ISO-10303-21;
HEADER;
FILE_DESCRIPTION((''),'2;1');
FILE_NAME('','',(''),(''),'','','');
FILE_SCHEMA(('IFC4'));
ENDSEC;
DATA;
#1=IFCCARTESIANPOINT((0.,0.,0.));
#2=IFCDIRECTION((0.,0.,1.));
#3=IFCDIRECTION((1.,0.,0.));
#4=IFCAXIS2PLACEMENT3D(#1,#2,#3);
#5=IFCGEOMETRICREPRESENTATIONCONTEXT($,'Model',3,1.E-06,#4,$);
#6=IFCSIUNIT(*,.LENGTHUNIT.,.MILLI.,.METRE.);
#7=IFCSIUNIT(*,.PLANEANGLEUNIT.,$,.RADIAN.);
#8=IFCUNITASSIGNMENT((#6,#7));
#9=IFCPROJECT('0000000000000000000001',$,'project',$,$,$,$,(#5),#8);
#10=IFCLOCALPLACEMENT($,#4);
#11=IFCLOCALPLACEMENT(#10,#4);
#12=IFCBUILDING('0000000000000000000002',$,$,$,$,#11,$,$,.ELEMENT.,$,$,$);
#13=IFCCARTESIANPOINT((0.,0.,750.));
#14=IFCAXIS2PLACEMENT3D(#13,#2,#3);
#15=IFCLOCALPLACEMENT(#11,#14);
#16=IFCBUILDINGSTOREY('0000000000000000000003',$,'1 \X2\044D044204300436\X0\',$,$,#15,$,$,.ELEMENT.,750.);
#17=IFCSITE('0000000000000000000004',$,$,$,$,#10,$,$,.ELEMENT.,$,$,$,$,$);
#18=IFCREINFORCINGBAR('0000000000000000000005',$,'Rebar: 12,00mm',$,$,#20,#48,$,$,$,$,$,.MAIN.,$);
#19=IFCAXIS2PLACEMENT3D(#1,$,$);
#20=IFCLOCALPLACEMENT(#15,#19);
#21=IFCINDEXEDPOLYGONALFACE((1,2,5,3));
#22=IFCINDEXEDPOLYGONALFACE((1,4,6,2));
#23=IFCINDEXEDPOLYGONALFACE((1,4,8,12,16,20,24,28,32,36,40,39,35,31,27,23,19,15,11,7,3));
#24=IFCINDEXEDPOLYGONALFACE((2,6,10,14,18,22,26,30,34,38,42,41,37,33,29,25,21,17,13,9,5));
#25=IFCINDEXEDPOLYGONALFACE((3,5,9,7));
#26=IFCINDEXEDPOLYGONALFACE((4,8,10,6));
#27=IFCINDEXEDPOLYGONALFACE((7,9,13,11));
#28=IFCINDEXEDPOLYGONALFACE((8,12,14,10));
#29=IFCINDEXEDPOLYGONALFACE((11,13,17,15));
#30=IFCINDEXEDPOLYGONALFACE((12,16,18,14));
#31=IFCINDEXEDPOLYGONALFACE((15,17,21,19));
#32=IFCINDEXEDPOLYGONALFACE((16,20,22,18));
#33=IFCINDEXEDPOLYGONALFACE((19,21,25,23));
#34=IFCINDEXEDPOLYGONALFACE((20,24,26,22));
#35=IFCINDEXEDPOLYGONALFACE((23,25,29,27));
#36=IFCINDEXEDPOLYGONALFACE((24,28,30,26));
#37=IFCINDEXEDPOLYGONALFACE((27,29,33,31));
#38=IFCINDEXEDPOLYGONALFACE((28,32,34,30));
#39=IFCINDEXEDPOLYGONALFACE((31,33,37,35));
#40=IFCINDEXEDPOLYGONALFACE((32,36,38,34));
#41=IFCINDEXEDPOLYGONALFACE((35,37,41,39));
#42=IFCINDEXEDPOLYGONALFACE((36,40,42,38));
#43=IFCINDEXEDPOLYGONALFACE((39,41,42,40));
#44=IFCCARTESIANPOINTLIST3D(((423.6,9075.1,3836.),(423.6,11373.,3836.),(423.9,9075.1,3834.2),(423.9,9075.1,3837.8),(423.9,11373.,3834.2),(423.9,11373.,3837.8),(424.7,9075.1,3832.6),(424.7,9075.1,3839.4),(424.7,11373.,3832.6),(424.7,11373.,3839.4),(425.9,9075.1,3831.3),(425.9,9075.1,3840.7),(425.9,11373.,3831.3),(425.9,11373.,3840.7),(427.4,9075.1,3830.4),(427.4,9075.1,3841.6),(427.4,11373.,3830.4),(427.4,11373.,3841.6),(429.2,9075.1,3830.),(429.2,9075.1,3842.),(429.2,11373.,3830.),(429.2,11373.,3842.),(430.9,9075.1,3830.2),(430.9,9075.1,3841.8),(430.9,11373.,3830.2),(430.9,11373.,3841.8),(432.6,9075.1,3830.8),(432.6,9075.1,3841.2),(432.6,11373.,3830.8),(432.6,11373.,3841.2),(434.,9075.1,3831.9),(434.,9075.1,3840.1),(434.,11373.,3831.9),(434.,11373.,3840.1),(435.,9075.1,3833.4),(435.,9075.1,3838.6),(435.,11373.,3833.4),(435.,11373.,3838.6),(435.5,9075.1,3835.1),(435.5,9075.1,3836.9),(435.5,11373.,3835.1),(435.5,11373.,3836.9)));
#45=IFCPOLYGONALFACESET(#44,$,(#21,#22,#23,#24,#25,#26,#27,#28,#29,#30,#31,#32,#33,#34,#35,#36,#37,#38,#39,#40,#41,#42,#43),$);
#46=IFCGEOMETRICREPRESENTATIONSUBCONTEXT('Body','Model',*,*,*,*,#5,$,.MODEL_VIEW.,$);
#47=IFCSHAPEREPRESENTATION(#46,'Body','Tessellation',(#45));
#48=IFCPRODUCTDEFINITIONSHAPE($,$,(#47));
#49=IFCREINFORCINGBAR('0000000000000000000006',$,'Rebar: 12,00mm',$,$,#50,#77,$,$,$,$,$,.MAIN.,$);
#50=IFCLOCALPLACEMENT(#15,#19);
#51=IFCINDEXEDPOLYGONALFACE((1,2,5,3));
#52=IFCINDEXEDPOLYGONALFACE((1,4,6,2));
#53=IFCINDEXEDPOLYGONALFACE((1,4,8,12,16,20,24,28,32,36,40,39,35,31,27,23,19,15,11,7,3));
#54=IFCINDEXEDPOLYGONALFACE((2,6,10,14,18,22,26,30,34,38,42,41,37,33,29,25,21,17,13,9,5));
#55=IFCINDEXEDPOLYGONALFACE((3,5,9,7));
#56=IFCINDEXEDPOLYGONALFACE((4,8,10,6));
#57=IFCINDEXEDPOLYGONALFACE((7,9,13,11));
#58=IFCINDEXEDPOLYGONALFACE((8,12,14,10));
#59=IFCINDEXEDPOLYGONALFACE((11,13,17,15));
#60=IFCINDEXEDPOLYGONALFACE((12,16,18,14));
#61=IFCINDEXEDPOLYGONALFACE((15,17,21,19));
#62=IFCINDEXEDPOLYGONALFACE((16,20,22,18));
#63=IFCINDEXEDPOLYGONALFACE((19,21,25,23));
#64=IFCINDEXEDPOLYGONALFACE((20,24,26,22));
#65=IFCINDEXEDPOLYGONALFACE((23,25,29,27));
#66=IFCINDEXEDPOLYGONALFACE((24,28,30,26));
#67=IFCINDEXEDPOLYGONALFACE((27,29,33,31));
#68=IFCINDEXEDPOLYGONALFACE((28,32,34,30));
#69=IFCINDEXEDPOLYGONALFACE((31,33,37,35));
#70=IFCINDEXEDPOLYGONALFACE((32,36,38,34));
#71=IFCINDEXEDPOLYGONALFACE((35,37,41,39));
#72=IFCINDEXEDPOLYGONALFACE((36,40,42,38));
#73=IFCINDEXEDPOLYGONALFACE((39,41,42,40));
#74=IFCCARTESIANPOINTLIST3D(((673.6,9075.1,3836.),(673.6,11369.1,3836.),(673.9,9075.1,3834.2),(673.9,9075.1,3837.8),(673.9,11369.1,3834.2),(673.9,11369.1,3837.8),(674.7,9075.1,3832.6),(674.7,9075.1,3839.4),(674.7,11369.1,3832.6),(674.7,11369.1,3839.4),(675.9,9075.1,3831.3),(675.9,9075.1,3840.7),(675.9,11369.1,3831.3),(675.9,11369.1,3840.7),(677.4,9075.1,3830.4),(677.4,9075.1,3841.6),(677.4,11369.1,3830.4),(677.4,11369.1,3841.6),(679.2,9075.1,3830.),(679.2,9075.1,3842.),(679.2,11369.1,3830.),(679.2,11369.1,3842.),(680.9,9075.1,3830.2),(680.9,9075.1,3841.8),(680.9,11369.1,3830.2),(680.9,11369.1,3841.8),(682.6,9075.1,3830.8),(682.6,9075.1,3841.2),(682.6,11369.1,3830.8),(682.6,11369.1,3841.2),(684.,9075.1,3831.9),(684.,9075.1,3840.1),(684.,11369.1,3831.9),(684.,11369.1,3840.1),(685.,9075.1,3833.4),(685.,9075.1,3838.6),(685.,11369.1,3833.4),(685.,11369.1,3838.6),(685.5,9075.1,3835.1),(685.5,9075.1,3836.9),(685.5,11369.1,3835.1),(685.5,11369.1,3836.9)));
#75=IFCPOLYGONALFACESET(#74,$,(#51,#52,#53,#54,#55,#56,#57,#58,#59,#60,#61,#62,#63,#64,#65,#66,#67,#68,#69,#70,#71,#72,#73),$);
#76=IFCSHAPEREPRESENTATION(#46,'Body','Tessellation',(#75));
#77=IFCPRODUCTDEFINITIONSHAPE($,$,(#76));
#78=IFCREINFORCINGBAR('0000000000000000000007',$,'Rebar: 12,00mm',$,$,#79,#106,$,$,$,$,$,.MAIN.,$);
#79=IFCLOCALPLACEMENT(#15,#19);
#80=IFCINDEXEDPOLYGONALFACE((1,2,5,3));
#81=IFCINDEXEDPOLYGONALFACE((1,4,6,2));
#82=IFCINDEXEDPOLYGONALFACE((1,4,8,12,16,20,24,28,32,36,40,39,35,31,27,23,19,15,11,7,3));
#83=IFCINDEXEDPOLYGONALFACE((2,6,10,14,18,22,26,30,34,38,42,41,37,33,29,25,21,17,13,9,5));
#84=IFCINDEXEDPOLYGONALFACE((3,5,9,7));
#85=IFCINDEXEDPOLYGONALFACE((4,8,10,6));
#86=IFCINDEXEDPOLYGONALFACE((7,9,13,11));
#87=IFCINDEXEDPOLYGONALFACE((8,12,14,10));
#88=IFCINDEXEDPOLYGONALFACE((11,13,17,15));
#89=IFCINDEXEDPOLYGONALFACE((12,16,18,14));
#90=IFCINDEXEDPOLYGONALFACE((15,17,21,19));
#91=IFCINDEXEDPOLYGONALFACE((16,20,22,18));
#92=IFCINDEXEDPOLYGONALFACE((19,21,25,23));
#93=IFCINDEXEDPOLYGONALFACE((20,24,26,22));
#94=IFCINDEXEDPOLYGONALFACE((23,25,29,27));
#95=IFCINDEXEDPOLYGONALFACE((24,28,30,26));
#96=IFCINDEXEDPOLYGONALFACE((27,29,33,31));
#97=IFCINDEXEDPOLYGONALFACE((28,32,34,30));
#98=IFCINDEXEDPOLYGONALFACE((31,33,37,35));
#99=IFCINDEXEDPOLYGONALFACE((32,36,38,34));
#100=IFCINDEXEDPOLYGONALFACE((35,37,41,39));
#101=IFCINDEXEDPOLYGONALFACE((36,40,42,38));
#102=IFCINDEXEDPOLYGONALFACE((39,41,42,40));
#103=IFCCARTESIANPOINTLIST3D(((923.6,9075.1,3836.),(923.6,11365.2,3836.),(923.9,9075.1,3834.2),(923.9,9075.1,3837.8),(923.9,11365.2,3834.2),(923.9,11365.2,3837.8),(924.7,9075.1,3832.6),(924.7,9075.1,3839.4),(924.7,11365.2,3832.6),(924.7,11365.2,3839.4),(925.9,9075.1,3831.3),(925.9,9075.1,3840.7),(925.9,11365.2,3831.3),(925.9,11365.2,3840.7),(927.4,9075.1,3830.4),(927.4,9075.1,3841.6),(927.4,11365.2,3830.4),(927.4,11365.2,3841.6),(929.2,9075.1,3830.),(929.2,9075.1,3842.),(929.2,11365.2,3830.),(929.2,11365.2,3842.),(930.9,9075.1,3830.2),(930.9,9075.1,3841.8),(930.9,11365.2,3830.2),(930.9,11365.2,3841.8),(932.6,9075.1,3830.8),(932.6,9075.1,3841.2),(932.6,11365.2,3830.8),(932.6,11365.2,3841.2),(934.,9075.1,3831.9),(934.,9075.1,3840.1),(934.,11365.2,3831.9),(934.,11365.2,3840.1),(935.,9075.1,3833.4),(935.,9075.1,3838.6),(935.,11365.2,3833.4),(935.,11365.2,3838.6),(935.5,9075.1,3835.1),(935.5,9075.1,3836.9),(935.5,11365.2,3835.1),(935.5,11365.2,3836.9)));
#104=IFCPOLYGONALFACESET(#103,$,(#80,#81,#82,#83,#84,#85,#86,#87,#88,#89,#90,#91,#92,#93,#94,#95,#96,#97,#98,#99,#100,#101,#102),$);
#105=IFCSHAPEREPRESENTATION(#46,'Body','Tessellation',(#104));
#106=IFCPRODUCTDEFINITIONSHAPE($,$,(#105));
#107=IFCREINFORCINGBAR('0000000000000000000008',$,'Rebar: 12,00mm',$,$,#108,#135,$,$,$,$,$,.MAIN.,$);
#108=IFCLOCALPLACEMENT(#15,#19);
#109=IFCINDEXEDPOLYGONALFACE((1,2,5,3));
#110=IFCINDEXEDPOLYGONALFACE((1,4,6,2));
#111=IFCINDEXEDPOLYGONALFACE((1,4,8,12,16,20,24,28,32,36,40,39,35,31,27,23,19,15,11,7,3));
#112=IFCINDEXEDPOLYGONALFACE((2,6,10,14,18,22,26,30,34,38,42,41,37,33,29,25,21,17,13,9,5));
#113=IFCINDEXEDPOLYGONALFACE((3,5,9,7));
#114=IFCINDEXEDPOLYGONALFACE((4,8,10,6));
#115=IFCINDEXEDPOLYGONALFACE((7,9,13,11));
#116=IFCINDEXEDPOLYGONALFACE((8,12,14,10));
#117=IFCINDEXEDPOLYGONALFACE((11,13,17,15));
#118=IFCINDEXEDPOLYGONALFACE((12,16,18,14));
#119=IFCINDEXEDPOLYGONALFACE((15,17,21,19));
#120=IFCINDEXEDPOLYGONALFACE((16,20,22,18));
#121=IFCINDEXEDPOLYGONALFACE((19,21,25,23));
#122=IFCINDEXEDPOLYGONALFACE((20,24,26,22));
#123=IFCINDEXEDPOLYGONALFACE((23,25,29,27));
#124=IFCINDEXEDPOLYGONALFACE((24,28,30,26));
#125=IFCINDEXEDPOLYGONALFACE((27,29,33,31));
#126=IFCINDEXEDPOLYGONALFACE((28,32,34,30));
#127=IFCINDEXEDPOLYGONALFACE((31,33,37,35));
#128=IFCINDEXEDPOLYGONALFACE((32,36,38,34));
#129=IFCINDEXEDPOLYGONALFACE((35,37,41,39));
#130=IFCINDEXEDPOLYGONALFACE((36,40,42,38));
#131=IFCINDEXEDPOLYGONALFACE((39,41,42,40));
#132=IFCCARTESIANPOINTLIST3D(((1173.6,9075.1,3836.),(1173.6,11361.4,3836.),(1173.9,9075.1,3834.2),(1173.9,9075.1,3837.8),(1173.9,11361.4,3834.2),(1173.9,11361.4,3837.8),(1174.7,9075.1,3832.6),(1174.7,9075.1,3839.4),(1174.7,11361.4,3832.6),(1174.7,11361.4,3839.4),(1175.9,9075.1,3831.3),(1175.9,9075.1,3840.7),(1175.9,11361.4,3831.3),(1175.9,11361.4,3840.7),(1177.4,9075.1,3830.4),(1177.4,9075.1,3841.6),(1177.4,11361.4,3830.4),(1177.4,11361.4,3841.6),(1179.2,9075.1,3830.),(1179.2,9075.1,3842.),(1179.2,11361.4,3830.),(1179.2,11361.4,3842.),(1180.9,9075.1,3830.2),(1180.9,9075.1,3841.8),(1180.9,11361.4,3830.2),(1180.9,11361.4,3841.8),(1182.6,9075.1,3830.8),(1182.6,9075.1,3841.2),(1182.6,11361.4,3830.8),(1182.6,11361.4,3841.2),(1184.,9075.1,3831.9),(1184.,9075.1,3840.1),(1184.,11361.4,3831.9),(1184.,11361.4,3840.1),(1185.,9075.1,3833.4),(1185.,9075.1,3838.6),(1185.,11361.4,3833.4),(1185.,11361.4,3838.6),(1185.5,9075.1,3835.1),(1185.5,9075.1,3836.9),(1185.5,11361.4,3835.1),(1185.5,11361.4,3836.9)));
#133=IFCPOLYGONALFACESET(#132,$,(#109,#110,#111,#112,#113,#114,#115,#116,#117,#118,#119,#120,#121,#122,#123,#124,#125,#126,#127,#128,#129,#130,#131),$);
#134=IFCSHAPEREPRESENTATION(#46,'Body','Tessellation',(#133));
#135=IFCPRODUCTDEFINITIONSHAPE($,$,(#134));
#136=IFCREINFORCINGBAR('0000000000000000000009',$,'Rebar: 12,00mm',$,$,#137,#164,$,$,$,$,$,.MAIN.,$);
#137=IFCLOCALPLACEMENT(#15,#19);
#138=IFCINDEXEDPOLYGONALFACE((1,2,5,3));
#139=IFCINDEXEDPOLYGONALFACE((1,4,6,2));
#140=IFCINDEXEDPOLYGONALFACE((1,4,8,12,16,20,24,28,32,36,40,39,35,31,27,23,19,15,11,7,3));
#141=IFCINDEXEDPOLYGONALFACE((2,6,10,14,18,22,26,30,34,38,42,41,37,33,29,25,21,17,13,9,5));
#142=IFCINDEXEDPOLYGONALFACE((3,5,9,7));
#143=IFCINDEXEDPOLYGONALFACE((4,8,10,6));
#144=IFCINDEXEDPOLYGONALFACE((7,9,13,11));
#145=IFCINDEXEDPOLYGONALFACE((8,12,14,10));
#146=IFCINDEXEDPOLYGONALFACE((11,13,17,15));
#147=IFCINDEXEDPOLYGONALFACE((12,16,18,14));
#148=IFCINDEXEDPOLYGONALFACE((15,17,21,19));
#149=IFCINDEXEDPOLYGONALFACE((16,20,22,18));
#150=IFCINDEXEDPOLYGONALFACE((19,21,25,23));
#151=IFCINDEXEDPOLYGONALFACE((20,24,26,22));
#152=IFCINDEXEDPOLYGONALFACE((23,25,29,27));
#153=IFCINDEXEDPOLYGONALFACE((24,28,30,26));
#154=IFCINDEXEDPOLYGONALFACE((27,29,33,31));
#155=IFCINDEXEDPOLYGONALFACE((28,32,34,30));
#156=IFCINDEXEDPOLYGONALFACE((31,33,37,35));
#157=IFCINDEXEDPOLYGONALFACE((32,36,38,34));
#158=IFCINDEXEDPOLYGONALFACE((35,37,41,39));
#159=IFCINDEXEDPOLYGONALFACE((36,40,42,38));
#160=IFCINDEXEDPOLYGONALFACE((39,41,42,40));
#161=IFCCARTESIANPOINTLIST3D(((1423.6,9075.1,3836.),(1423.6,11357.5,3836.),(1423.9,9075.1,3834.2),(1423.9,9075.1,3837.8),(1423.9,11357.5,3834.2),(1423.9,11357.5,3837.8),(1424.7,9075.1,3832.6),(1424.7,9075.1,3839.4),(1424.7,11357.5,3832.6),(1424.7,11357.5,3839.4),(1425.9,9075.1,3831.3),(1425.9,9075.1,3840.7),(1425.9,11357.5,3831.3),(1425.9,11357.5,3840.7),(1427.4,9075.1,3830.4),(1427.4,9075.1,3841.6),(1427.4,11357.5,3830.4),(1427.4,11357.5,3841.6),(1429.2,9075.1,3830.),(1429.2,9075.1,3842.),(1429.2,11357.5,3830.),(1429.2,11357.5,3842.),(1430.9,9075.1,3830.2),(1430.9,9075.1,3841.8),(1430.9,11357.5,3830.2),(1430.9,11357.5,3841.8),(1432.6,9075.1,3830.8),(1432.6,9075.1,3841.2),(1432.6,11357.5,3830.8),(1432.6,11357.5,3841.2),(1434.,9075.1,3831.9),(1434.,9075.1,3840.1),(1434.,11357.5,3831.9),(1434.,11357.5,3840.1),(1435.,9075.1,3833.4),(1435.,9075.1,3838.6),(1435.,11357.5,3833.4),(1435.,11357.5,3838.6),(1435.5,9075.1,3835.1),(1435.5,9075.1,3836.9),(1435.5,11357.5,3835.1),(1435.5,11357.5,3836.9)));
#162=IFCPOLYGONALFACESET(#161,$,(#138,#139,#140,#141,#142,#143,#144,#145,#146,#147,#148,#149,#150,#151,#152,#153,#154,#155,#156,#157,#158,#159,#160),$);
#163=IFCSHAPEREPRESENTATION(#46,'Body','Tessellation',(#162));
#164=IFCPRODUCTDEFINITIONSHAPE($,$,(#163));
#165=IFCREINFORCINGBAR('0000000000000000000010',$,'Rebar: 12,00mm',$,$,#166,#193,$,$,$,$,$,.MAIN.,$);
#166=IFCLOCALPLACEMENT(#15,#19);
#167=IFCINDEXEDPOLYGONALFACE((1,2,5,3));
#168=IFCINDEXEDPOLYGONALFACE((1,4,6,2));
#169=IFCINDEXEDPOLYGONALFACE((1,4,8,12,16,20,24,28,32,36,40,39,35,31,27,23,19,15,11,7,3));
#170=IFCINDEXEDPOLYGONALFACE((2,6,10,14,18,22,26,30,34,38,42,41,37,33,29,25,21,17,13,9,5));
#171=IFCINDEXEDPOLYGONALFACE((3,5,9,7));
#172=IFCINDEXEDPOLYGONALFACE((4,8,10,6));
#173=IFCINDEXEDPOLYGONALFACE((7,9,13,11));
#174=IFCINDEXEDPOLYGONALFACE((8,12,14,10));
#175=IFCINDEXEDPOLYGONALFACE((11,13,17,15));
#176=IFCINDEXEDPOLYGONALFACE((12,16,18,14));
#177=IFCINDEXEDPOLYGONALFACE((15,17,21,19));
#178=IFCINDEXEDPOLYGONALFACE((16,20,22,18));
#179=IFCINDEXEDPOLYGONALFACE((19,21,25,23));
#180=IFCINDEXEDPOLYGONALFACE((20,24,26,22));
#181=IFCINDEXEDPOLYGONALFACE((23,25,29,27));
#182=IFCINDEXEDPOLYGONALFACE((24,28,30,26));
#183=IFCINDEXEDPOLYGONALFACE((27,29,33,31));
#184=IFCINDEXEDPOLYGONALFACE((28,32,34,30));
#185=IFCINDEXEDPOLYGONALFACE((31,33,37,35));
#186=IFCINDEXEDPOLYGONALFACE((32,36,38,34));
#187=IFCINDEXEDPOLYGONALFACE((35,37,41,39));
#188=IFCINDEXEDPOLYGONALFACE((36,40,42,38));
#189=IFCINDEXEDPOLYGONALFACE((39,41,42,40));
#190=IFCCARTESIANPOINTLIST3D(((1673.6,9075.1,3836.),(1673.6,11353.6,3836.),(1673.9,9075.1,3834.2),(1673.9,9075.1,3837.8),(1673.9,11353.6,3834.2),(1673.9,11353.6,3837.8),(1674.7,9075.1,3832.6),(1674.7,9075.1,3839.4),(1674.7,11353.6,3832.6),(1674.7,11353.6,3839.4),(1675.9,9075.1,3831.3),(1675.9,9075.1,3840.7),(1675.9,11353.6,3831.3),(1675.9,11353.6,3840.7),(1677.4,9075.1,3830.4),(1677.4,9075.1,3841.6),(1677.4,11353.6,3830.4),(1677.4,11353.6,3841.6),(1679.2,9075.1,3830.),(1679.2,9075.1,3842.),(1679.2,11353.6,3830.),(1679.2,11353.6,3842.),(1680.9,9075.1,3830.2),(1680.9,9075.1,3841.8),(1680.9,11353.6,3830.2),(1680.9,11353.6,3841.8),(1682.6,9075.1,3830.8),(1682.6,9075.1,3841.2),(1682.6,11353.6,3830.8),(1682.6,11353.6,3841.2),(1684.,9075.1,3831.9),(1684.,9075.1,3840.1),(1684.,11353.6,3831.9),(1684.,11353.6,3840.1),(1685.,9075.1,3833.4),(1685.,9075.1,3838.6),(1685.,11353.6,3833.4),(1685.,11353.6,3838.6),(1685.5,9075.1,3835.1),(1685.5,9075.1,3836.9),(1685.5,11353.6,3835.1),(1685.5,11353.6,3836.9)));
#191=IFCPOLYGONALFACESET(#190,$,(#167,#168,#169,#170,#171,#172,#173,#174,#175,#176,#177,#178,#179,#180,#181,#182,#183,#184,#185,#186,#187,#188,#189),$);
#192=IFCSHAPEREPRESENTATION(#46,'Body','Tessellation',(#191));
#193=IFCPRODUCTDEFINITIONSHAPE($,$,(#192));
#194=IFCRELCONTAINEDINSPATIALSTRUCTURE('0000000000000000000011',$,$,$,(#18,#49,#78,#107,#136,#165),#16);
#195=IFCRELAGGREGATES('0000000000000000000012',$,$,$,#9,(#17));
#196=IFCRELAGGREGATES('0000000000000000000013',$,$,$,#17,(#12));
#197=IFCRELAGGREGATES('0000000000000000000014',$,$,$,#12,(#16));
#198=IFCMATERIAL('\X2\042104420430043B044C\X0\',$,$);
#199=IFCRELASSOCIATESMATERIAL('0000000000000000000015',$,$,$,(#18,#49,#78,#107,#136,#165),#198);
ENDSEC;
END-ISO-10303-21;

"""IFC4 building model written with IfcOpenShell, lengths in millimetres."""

from ifc_helpers import new_model, entity, si_unit, frame, origin_with_axes, place, context, subcontext, project, spatial, source, transform, mapped, material, element, save


model = new_model("IFC4")

# Units and contexts
model_context = context("Model", 3, precision=1e-06, world=origin_with_axes())
body_context = subcontext(model_context, "Body", "Model", "MODEL_VIEW")
ifc_project = project(units=[si_unit("LENGTHUNIT", "METRE", prefix="MILLI"), si_unit("PLANEANGLEUNIT", "RADIAN")], contexts=[model_context])

# Site, building, storey
site_placement = place(None, origin_with_axes())
site = spatial("IfcSite", under=ifc_project, at=site_placement, CompositionType="ELEMENT")
building_placement = place(site_placement, origin_with_axes())
building = spatial("IfcBuilding", under=site, at=building_placement, CompositionType="ELEMENT")
storey_placement = place(building_placement, frame((0.0, 0.0, 750.0), z_axis=(0.0, 0.0, 1.0), x_axis=(1.0, 0.0, 0.0)))
storey = spatial("IfcBuildingStorey", under=building, at=storey_placement, Name="1 этаж", CompositionType="ELEMENT", Elevation=750.0)

# Reinforcing bars
ifc_material = material(Name="Сталь")
shared_shape_1 = source(origin_with_axes(), body_context, "Body", "AdvancedSweptSolid", [
    entity("IfcSweptDiskSolid", entity("IfcIndexedPolyCurve", entity("IfcCartesianPointList3D", [[0.0, 0.0, 0.0], [2297.9, 0.0, 0.0]]), [entity("IfcLineIndex", [1, 2])]), 6.0),
])
reinforcing_bar_1_placement = place(storey_placement, origin_with_axes())
element("IfcReinforcingBar", 1, at=reinforcing_bar_1_placement, inside=storey, material=ifc_material, Name="Rebar: 12,00mm", PredefinedType="MAIN", context=body_context, shape_type="MappedRepresentation", body=[
    mapped(shared_shape_1, transform((429.6, 9075.1, 3836.0), x_axis=(0.0, 1.0, 0.0), y_axis=(-1.0, 0.0, 0.0), z_axis=(0.0, 0.0, 1.0), scale=1.0)),
])
shared_shape_2 = source(origin_with_axes(), body_context, "Body", "AdvancedSweptSolid", [
    entity("IfcSweptDiskSolid", entity("IfcIndexedPolyCurve", entity("IfcCartesianPointList3D", [[0.0, 0.0, 0.0], [2294.0, 0.0, 0.0]]), [entity("IfcLineIndex", [1, 2])]), 6.0),
])
reinforcing_bar_2_placement = place(storey_placement, origin_with_axes())
element("IfcReinforcingBar", 2, at=reinforcing_bar_2_placement, inside=storey, material=ifc_material, Name="Rebar: 12,00mm", PredefinedType="MAIN", context=body_context, shape_type="MappedRepresentation", body=[
    mapped(shared_shape_2, transform((679.6, 9075.1, 3836.0), x_axis=(0.0, 1.0, 0.0), y_axis=(-1.0, 0.0, 0.0), z_axis=(0.0, 0.0, 1.0), scale=1.0)),
])
shared_shape_3 = source(origin_with_axes(), body_context, "Body", "AdvancedSweptSolid", [
    entity("IfcSweptDiskSolid", entity("IfcIndexedPolyCurve", entity("IfcCartesianPointList3D", [[0.0, 0.0, 0.0], [2290.1, 0.0, 0.0]]), [entity("IfcLineIndex", [1, 2])]), 6.0),
])
reinforcing_bar_3_placement = place(storey_placement, origin_with_axes())
element("IfcReinforcingBar", 3, at=reinforcing_bar_3_placement, inside=storey, material=ifc_material, Name="Rebar: 12,00mm", PredefinedType="MAIN", context=body_context, shape_type="MappedRepresentation", body=[
    mapped(shared_shape_3, transform((929.6, 9075.1, 3836.0), x_axis=(0.0, 1.0, 0.0), y_axis=(-1.0, 0.0, 0.0), z_axis=(0.0, 0.0, 1.0), scale=1.0)),
])
shared_shape_4 = source(origin_with_axes(), body_context, "Body", "AdvancedSweptSolid", [
    entity("IfcSweptDiskSolid", entity("IfcIndexedPolyCurve", entity("IfcCartesianPointList3D", [[0.0, 0.0, 0.0], [2286.2, 0.0, 0.0]]), [entity("IfcLineIndex", [1, 2])]), 6.0),
])
reinforcing_bar_4_placement = place(storey_placement, origin_with_axes())
element("IfcReinforcingBar", 4, at=reinforcing_bar_4_placement, inside=storey, material=ifc_material, Name="Rebar: 12,00mm", PredefinedType="MAIN", context=body_context, shape_type="MappedRepresentation", body=[
    mapped(shared_shape_4, transform((1179.6, 9075.1, 3836.0), x_axis=(0.0, 1.0, 0.0), y_axis=(-1.0, 0.0, 0.0), z_axis=(0.0, 0.0, 1.0), scale=1.0)),
])
shared_shape_5 = source(origin_with_axes(), body_context, "Body", "AdvancedSweptSolid", [
    entity("IfcSweptDiskSolid", entity("IfcIndexedPolyCurve", entity("IfcCartesianPointList3D", [[0.0, 0.0, 0.0], [2282.4, 0.0, 0.0]]), [entity("IfcLineIndex", [1, 2])]), 6.0),
])
reinforcing_bar_5_placement = place(storey_placement, origin_with_axes())
element("IfcReinforcingBar", 5, at=reinforcing_bar_5_placement, inside=storey, material=ifc_material, Name="Rebar: 12,00mm", PredefinedType="MAIN", context=body_context, shape_type="MappedRepresentation", body=[
    mapped(shared_shape_5, transform((1429.6, 9075.1, 3836.0), x_axis=(0.0, 1.0, 0.0), y_axis=(-1.0, 0.0, 0.0), z_axis=(0.0, 0.0, 1.0), scale=1.0)),
])
shared_shape_6 = source(origin_with_axes(), body_context, "Body", "AdvancedSweptSolid", [
    entity("IfcSweptDiskSolid", entity("IfcIndexedPolyCurve", entity("IfcCartesianPointList3D", [[0.0, 0.0, 0.0], [2278.5, 0.0, 0.0]]), [entity("IfcLineIndex", [1, 2])]), 6.0),
])
reinforcing_bar_6_placement = place(storey_placement, origin_with_axes())
element("IfcReinforcingBar", 6, at=reinforcing_bar_6_placement, inside=storey, material=ifc_material, Name="Rebar: 12,00mm", PredefinedType="MAIN", context=body_context, shape_type="MappedRepresentation", body=[
    mapped(shared_shape_6, transform((1679.6, 9075.1, 3836.0), x_axis=(0.0, 1.0, 0.0), y_axis=(-1.0, 0.0, 0.0), z_axis=(0.0, 0.0, 1.0), scale=1.0)),
])

save(model, "model.ifc")
